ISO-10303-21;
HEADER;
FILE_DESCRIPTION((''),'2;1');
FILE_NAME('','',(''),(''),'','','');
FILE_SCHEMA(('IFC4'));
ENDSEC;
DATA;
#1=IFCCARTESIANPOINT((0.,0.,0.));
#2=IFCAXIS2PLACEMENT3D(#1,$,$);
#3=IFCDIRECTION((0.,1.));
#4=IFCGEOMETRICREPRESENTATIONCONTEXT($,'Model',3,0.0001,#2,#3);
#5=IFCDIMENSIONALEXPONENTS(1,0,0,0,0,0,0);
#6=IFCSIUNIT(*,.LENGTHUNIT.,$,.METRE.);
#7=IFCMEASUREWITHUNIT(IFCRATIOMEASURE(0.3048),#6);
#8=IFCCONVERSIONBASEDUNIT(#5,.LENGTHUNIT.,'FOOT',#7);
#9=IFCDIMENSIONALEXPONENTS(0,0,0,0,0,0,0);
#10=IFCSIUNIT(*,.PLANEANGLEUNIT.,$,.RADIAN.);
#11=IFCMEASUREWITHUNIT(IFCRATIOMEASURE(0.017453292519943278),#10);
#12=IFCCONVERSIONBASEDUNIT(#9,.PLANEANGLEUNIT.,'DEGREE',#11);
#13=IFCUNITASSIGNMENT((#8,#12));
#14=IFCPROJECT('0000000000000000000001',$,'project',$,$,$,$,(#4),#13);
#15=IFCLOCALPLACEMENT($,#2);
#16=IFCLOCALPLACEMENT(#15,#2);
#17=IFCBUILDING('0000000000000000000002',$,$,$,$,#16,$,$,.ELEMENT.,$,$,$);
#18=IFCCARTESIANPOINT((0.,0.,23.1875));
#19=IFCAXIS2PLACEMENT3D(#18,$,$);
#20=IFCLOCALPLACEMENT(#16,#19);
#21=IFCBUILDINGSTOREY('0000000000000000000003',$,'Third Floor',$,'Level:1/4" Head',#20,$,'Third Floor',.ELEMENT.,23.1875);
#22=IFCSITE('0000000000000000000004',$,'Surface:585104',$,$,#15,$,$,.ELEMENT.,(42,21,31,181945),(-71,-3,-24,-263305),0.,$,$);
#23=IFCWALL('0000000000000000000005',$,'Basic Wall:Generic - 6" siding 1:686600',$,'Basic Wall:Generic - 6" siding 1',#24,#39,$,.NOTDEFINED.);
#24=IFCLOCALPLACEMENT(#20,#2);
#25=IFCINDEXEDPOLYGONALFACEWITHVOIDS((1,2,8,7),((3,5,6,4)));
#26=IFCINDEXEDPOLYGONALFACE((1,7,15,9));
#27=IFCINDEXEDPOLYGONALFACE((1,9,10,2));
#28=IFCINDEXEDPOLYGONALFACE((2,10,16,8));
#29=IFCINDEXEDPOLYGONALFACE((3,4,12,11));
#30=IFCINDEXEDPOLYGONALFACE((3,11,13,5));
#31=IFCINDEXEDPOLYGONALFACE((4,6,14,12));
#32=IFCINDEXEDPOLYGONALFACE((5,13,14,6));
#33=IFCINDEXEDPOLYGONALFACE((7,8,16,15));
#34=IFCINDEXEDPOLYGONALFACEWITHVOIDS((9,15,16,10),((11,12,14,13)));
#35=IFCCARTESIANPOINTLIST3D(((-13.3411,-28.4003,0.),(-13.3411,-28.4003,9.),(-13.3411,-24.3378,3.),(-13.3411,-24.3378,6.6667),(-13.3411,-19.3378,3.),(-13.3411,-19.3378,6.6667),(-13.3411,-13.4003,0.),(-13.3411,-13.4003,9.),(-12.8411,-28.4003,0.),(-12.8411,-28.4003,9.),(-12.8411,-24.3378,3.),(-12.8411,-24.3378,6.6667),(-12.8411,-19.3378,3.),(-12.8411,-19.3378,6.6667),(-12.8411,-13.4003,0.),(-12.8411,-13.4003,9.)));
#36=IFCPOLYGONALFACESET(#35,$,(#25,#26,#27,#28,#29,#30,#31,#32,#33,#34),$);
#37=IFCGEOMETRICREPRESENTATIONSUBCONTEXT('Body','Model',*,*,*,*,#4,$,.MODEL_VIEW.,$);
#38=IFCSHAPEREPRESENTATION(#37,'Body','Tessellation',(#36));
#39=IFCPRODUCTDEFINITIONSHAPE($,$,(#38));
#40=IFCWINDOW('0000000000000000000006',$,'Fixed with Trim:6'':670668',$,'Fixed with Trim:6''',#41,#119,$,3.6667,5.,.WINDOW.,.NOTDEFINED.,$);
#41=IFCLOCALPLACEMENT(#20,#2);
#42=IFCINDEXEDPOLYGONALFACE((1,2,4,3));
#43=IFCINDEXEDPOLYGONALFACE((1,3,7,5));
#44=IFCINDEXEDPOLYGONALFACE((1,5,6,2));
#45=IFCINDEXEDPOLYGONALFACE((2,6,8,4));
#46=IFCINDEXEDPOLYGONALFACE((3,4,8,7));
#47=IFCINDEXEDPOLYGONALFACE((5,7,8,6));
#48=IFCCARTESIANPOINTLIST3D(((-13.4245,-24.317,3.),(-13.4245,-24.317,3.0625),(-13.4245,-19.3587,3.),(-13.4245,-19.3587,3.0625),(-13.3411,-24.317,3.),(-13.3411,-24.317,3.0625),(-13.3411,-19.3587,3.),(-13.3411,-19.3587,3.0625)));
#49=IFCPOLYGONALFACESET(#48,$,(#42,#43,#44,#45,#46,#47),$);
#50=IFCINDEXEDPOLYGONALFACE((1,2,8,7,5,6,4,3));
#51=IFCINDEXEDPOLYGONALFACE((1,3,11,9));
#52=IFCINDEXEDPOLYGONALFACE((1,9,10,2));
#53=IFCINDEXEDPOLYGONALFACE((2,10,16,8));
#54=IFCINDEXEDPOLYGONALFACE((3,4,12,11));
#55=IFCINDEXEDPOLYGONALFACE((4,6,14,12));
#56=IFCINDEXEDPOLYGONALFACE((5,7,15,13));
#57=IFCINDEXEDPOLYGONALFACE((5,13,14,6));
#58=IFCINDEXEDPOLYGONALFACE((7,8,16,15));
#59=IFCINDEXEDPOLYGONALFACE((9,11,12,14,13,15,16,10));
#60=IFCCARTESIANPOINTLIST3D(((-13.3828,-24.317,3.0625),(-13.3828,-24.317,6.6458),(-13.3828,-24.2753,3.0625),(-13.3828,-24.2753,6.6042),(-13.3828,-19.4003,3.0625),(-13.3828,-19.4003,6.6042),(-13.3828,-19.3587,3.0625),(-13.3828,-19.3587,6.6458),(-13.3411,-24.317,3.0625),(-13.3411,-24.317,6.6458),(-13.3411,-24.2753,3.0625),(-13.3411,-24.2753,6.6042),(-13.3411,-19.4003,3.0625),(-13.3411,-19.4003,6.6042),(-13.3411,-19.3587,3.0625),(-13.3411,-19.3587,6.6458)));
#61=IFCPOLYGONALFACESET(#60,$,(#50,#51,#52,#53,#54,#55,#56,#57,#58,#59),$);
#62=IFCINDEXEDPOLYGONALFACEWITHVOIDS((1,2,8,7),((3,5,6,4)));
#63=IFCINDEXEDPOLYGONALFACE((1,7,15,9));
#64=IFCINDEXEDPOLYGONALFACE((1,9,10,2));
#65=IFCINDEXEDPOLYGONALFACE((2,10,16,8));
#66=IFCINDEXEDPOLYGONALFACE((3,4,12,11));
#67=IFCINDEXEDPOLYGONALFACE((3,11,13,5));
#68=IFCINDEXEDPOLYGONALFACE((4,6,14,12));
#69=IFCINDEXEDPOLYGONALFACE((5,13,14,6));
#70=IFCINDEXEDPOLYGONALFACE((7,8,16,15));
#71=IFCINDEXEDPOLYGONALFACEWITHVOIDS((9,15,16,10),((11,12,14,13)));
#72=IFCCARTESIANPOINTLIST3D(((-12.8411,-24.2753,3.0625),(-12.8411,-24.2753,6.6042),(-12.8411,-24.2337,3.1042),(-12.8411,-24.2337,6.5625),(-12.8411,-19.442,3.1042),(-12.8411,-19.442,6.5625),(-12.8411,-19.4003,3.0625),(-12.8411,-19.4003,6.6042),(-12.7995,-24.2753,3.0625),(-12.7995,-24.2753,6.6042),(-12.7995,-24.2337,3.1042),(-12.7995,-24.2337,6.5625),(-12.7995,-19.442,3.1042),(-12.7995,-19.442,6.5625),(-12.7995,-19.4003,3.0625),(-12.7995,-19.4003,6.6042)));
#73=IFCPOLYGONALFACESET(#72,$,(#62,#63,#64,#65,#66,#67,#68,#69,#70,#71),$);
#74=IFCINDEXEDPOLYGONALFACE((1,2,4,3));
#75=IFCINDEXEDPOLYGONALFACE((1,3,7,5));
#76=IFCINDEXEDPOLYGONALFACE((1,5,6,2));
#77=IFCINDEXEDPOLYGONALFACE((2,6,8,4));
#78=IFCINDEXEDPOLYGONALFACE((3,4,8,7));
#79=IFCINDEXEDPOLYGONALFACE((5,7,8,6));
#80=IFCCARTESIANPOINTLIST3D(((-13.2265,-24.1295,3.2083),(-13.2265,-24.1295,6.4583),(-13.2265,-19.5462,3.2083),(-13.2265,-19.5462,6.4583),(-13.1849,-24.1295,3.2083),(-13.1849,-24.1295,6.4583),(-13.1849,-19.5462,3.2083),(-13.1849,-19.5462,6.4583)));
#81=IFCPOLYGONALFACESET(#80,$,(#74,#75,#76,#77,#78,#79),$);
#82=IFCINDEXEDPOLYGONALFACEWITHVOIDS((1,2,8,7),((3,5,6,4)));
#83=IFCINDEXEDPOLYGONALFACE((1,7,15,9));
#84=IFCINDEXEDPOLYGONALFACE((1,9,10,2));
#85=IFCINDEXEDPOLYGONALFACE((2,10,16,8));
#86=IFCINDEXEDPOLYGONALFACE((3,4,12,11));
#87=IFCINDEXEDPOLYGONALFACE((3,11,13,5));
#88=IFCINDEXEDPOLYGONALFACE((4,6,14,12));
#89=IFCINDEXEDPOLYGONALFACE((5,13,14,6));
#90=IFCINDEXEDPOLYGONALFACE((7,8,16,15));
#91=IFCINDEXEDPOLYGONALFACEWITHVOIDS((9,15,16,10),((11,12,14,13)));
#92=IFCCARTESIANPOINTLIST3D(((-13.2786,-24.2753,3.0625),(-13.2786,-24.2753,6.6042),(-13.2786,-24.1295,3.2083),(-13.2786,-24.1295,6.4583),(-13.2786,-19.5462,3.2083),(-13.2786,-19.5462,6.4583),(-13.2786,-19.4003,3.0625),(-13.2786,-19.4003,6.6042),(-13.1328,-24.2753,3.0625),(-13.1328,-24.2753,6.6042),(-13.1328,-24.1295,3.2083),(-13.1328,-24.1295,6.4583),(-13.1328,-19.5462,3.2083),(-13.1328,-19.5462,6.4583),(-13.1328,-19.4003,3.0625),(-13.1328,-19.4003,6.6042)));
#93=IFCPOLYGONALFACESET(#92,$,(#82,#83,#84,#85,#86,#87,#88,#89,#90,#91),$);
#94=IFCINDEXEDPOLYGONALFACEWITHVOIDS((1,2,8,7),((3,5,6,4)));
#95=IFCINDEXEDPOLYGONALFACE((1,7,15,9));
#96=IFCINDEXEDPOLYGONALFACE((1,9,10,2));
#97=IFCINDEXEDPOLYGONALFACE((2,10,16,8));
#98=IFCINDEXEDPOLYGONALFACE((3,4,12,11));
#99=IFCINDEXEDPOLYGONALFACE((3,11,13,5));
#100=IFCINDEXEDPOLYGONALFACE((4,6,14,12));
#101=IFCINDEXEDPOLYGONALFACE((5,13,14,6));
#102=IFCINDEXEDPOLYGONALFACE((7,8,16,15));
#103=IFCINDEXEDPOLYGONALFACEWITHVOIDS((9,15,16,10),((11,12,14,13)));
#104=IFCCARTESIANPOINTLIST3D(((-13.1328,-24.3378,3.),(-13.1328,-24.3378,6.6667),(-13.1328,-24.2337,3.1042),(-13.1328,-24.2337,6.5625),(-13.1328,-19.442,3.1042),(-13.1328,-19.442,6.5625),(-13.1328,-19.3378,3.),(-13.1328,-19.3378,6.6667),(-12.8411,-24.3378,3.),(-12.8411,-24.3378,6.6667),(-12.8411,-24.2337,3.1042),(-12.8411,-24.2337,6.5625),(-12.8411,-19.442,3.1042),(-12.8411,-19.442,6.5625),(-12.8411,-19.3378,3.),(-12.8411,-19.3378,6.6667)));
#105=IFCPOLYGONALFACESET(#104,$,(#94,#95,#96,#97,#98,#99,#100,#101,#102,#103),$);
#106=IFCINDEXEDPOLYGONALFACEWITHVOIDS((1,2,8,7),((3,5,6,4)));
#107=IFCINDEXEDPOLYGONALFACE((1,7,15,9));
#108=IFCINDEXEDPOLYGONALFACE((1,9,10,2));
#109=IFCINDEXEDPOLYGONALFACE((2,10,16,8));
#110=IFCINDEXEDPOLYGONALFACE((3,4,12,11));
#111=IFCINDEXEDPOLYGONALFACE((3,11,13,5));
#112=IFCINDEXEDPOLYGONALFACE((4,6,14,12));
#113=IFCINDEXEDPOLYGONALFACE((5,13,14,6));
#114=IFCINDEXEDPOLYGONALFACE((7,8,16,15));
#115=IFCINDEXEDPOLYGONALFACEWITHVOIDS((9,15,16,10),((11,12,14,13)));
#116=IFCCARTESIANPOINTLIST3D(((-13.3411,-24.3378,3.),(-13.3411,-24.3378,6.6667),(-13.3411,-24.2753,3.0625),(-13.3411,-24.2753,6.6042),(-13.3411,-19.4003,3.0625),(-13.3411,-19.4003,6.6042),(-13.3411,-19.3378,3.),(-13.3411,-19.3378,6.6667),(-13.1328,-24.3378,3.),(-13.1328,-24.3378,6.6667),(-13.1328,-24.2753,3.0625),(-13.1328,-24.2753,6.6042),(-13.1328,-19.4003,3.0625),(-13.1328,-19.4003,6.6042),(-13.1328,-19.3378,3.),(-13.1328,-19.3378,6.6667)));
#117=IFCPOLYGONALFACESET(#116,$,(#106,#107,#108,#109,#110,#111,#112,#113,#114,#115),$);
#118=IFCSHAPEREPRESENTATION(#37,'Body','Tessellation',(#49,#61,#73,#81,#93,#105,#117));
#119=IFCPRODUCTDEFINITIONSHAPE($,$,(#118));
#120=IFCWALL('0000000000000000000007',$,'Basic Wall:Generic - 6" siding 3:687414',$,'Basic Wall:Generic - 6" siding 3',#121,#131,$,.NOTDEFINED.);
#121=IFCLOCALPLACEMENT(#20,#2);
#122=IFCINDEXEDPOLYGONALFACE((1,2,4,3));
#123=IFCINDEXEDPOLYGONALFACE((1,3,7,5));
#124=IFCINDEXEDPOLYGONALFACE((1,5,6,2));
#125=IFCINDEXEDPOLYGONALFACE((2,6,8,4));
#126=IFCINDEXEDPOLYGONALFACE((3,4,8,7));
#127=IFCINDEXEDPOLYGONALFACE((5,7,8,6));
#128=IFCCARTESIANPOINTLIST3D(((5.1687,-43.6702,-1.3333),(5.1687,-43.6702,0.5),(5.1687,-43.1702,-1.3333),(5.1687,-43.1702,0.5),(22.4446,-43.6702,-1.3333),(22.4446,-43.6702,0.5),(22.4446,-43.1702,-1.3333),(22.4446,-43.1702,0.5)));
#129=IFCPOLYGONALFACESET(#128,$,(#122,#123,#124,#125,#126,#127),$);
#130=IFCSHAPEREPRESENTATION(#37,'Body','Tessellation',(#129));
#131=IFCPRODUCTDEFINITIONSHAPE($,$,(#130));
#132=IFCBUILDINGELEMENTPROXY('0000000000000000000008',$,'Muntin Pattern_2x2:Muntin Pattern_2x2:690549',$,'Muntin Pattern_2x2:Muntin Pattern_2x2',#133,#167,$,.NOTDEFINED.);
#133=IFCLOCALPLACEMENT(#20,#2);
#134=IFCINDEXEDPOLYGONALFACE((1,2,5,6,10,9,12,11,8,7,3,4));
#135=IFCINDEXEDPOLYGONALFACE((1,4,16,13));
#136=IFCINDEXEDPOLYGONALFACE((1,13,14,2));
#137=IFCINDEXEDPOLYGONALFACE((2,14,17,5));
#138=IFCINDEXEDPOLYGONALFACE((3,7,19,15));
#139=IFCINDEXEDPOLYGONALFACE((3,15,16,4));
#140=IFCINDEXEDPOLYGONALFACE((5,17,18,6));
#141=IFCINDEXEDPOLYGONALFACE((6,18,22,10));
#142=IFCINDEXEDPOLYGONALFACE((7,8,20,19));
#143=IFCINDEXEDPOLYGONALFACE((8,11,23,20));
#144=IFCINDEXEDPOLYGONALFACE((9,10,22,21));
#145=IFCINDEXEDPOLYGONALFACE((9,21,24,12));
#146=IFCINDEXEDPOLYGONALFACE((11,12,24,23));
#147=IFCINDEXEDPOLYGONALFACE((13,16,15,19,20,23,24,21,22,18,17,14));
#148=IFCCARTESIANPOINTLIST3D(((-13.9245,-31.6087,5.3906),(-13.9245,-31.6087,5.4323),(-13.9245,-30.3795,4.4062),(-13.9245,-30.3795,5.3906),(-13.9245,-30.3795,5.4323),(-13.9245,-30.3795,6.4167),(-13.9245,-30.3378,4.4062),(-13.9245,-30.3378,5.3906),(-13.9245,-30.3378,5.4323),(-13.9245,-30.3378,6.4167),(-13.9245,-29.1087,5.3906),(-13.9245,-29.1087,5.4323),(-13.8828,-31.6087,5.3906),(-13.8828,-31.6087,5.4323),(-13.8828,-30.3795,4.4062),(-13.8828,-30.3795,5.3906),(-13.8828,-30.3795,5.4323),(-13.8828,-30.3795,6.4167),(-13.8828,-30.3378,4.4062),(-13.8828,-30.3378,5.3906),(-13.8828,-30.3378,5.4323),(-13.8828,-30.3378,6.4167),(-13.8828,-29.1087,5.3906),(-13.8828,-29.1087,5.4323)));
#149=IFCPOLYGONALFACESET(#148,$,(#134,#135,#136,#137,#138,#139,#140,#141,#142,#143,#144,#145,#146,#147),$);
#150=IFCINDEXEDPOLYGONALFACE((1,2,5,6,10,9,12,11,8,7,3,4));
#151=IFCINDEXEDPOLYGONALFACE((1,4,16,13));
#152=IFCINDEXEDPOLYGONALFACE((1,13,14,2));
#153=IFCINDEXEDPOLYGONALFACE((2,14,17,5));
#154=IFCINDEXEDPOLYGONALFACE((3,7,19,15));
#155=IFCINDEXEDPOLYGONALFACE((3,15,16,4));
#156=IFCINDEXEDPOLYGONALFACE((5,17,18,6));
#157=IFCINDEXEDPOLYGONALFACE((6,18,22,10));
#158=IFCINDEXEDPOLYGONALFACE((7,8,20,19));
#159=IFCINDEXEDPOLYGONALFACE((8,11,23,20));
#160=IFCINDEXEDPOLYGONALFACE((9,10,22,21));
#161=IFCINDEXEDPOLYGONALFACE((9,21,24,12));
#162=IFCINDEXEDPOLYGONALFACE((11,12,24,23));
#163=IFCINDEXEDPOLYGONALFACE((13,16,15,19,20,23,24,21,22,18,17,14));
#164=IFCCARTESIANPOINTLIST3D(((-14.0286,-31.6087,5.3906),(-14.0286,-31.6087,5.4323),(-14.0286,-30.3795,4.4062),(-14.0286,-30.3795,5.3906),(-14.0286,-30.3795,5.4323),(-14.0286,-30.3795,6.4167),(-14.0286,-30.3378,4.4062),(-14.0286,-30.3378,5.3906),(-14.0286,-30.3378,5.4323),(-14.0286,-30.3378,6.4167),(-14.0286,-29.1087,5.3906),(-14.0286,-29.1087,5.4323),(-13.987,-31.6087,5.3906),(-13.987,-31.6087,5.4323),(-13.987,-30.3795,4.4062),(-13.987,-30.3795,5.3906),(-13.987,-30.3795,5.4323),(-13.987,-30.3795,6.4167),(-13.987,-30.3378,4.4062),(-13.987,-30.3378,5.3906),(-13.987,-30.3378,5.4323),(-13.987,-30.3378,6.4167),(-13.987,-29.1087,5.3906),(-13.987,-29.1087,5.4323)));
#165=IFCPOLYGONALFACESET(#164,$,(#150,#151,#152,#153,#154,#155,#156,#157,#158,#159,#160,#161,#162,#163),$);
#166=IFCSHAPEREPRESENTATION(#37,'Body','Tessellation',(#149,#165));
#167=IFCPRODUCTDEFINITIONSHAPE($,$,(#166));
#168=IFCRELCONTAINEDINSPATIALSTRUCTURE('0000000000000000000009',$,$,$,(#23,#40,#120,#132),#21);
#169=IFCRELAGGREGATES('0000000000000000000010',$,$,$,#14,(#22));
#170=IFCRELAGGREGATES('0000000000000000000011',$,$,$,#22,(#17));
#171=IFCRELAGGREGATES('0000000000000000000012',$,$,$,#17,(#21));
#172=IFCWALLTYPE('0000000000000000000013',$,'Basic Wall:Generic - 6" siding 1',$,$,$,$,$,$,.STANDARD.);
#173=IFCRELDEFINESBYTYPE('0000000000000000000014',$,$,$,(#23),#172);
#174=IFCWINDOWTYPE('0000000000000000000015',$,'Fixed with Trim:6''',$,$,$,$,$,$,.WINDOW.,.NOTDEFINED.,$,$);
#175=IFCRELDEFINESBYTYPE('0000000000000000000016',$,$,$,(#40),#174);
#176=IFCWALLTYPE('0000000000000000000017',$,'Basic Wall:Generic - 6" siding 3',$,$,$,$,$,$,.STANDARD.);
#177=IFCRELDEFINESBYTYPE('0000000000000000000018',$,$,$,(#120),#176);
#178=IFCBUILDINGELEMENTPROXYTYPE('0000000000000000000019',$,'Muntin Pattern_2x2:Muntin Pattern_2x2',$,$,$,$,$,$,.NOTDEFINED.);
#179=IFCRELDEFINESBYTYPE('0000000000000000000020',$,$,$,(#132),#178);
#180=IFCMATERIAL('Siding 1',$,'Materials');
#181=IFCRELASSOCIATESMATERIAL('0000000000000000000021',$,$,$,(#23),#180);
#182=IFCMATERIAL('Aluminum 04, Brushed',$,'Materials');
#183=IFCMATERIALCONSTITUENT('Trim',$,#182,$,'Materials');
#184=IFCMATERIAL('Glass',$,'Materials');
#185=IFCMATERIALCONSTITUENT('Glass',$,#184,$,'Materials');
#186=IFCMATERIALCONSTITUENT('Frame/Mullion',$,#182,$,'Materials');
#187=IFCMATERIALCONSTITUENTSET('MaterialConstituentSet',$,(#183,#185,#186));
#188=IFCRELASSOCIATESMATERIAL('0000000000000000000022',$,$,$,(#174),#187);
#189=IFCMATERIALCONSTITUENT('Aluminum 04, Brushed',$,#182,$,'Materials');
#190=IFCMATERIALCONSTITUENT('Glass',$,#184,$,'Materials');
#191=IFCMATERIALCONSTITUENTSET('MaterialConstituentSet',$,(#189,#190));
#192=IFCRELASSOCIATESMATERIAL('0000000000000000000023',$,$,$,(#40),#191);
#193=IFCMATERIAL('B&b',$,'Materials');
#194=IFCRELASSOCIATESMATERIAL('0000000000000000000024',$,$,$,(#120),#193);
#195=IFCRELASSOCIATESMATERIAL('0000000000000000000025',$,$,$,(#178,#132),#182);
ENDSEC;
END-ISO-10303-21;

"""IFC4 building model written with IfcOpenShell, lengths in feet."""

from ifc_helpers import new_model, entity, si_unit, converted_unit, direction, frame, origin, place, context, subcontext, project, spatial, indexed_curve, outline, extrude, source, transform, mapped, material, constituent, constituent_set, type_object, type_shapes, element, fill, save


model = new_model("IFC4")

# Units and contexts
model_context = context("Model", 3, precision=0.0001, world=origin(), true_north=direction((0.0, 1.0)))
body_context = subcontext(model_context, "Body", "Model", "MODEL_VIEW")
ifc_project = project(units=[converted_unit("LENGTHUNIT", "FOOT", entity("IfcRatioMeasure", 0.3048), si_unit("LENGTHUNIT", "METRE"), dimensions=[1, 0, 0, 0, 0, 0, 0]), converted_unit("PLANEANGLEUNIT", "DEGREE", entity("IfcRatioMeasure", 0.017453292519943278), si_unit("PLANEANGLEUNIT", "RADIAN"), dimensions=[0, 0, 0, 0, 0, 0, 0])], contexts=[model_context])

# Site, building, storey
site_placement = place(None, origin())
site = spatial("IfcSite", under=ifc_project, at=site_placement, Name="Surface:585104", CompositionType="ELEMENT", RefLatitude=(42, 21, 31, 181945), RefLongitude=(-71, -3, -24, -263305), RefElevation=0.0)
building_placement = place(site_placement, origin())
building = spatial("IfcBuilding", under=site, at=building_placement, CompositionType="ELEMENT")
storey_placement = place(building_placement, frame((0.0, 0.0, 23.1875)))
storey = spatial("IfcBuildingStorey", under=building, at=storey_placement, Name="Third Floor", ObjectType="Level:1/4\" Head", LongName="Third Floor", CompositionType="ELEMENT", Elevation=23.1875)

# Wall, openings, window
ifc_material_1 = material(Name="Siding 1", Category="Materials")
wall_type_1 = type_object("IfcWallType", Name="Basic Wall:Generic - 6\" siding 1", PredefinedType="STANDARD")
wall_1_placement = place(storey_placement, frame((-13.0911, -28.4003, 0.0), z_axis=(0.0, 0.0, 1.0), x_axis=(0.0, 1.0, 0.0)))
wall_1 = element("IfcWall", 1, at=wall_1_placement, inside=storey, type_object=wall_type_1, material=ifc_material_1, Name="Basic Wall:Generic - 6\" siding 1:686600", ObjectType="Basic Wall:Generic - 6\" siding 1", PredefinedType="NOTDEFINED", context=body_context, shape_type="SweptSolid", body=[
    extrude(outline(indexed_curve([(-0.25, -7.5), (0.25, -7.5), (0.25, 7.5), (-0.25, 7.5), (-0.25, -7.5)], self_intersect=False)), frame((7.5, 0.0, 0.0), z_axis=(0.0, 0.0, 1.0), x_axis=(0.0, 1.0, 0.0)), (0.0, 0.0, 1.0), 9.0),
])
opening_1_placement = place(storey_placement, frame((-13.0911, -28.4003, 0.0), z_axis=(0.0, 0.0, 1.0), x_axis=(0.0, 1.0, 0.0)))
element("IfcOpeningElement", 2, at=opening_1_placement, cuts=wall_1, PredefinedType="OPENING", context=body_context, shape_type="SweptSolid", body=[
    extrude(outline(indexed_curve([(-2.5, -1.8333), (2.5, -1.8333), (2.5, 1.8333), (-2.5, 1.8333), (-2.5, -1.8333)], self_intersect=False)), frame((6.5625, 0.25, 4.8333), z_axis=(0.0, -1.0, 0.0), x_axis=(-1.0, 0.0, 0.0)), (0.0, 0.0, 1.0), 0.5),
])
opening_2_placement = place(wall_1_placement, frame((4.0625, -0.25, 3.0)))
opening_2 = element("IfcOpeningElement", 3, at=opening_2_placement, cuts=wall_1, PredefinedType="OPENING", context=body_context, shape_type="SweptSolid", body=[
    extrude(outline(indexed_curve([(3.6667, 5.0), (0.0, 5.0), (0.0, 0.0), (3.6667, 0.0), (3.6667, 5.0)], self_intersect=False)), frame((0.0, 0.0, 0.0), z_axis=(0.0, 1.0, 0.0), x_axis=(0.0, 0.0, 1.0)), (0.0, 0.0, 1.0), 0.5),
])
ifc_material_2 = material(Name="Aluminum 04, Brushed", Category="Materials")
ifc_constituent_1 = constituent(ifc_material_2, Name="Aluminum 04, Brushed", Category="Materials")
ifc_material_3 = material(Name="Glass", Category="Materials")
ifc_constituent_2 = constituent(ifc_material_3, Name="Glass", Category="Materials")
ifc_constituent_set_1 = constituent_set(constituents=[ifc_constituent_1, ifc_constituent_2], Name="MaterialConstituentSet")
ifc_constituent_3 = constituent(ifc_material_2, Name="Trim", Category="Materials")
ifc_constituent_4 = constituent(ifc_material_3, Name="Glass", Category="Materials")
ifc_constituent_5 = constituent(ifc_material_2, Name="Frame/Mullion", Category="Materials")
ifc_constituent_set_2 = constituent_set(constituents=[ifc_constituent_3, ifc_constituent_4, ifc_constituent_5], Name="MaterialConstituentSet")
window_type = type_object("IfcWindowType", Name="Fixed with Trim:6'", PartitioningType="NOTDEFINED", PredefinedType="WINDOW", material=ifc_constituent_set_2)
shared_shape_1 = source(origin(), body_context, "Body", "SweptSolid", [
    extrude(outline(indexed_curve([(-0.0417, -2.4792), (0.0417, -2.4792), (0.0417, 2.4792), (-0.0417, 2.4792), (-0.0417, -2.4792)], self_intersect=False)), frame((2.5, 0.5417, 0.0), z_axis=(0.0, 0.0, 1.0), x_axis=(0.0, -1.0, 0.0)), (0.0, 0.0, 1.0), 0.0625),
    extrude(outline(indexed_curve([(-1.7604, 2.4375), (1.7812, 2.4375), (1.7812, 2.4792), (-1.8021, 2.4792), (-1.8021, -2.4792), (1.7812, -2.4792), (1.7812, -2.4375), (-1.7604, -2.4375), (-1.7604, 2.4375)], self_intersect=False)), frame((2.5, 0.5, 1.8437), z_axis=(0.0, 1.0, 0.0), x_axis=(0.0, 0.0, -1.0)), (0.0, 0.0, 1.0), 0.0417),
    extrude(outline(indexed_curve([(-1.7708, -2.4375), (1.7708, -2.4375), (1.7708, 2.4375), (-1.7708, 2.4375), (-1.7708, -2.4375)], self_intersect=False), holes=[indexed_curve([(-1.7292, -2.3958), (-1.7292, 2.3958), (1.7292, 2.3958), (1.7292, -2.3958), (-1.7292, -2.3958)], self_intersect=False)]), frame((2.5, -0.0417, 1.8333), z_axis=(0.0, 1.0, 0.0), x_axis=(0.0, 0.0, -1.0)), (0.0, 0.0, 1.0), 0.0417),
    extrude(outline(indexed_curve([(-0.0208, -2.2917), (0.0208, -2.2917), (0.0208, 2.2917), (-0.0208, 2.2917), (-0.0208, -2.2917)], self_intersect=False)), frame((2.5, 0.3646, 0.2083), z_axis=(0.0, 0.0, 1.0), x_axis=(0.0, 1.0, 0.0)), (0.0, 0.0, 1.0), 3.25),
    extrude(outline(indexed_curve([(-2.4375, -1.7708), (2.4375, -1.7708), (2.4375, 1.7708), (-2.4375, 1.7708), (-2.4375, -1.7708)], self_intersect=False), holes=[indexed_curve([(-2.2917, -1.625), (-2.2917, 1.625), (2.2917, 1.625), (2.2917, -1.625), (-2.2917, -1.625)], self_intersect=False)]), frame((2.5, 0.2917, 1.8333), z_axis=(0.0, 1.0, 0.0), x_axis=(1.0, 0.0, 0.0)), (0.0, 0.0, 1.0), 0.1458),
    extrude(outline(indexed_curve([(-2.5, -1.8333), (2.5, -1.8333), (2.5, 1.8333), (-2.5, 1.8333), (-2.5, -1.8333)], self_intersect=False), holes=[indexed_curve([(-2.3958, -1.7292), (-2.3958, 1.7292), (2.3958, 1.7292), (2.3958, -1.7292), (-2.3958, -1.7292)], self_intersect=False)]), frame((2.5, 0.0, 1.8333), z_axis=(0.0, 1.0, 0.0), x_axis=(1.0, 0.0, 0.0)), (0.0, 0.0, 1.0), 0.2917),
    extrude(outline(indexed_curve([(-1.8333, -2.5), (1.8333, -2.5), (1.8333, 2.5), (-1.8333, 2.5), (-1.8333, -2.5)], self_intersect=False), holes=[indexed_curve([(-1.7708, -2.4375), (-1.7708, 2.4375), (1.7708, 2.4375), (1.7708, -2.4375), (-1.7708, -2.4375)], self_intersect=False)]), frame((2.5, 0.2917, 1.8333), z_axis=(0.0, 1.0, 0.0), x_axis=(0.0, 0.0, -1.0)), (0.0, 0.0, 1.0), 0.2083),
])
type_shapes(window_type, [shared_shape_1])
window_placement = place(opening_2_placement, origin())
window = element("IfcWindow", 4, at=window_placement, inside=storey, type_object=window_type, material=ifc_constituent_set_1, Name="Fixed with Trim:6':670668", ObjectType="Fixed with Trim:6'", OverallHeight=3.6667, OverallWidth=5.0, PartitioningType="NOTDEFINED", PredefinedType="WINDOW", context=body_context, shape_type="MappedRepresentation", body=[
    mapped(shared_shape_1, transform((0.0, 0.0, 0.0), scale=1.0)),
])
fill(opening_2, window)

# Wall
ifc_material_4 = material(Name="B&b", Category="Materials")
wall_type_2 = type_object("IfcWallType", Name="Basic Wall:Generic - 6\" siding 3", PredefinedType="STANDARD")
wall_2_placement = place(storey_placement, frame((5.1687, -43.4202, -1.3333)))
element("IfcWall", 5, at=wall_2_placement, inside=storey, type_object=wall_type_2, material=ifc_material_4, Name="Basic Wall:Generic - 6\" siding 3:687414", ObjectType="Basic Wall:Generic - 6\" siding 3", PredefinedType="NOTDEFINED", context=body_context, shape_type="SweptSolid", body=[
    extrude(outline(indexed_curve([(17.2759, -0.25), (17.2759, 0.25), (0.0, 0.25), (0.0, -0.25), (17.2759, -0.25)], self_intersect=False)), origin(), (0.0, 0.0, 1.0), 1.8333),
])

# Building element proxy
building_element_proxy_type_1 = type_object("IfcBuildingElementProxyType", Name="Muntin Pattern_2x2:Muntin Pattern_2x2", PredefinedType="NOTDEFINED", material=ifc_material_2)
shared_shape_2 = source(origin(), body_context, "Body", "SweptSolid", [
    extrude(outline(indexed_curve([(0.0208, -0.0208), (1.0052, -0.0208), (1.0052, 0.0208), (0.0208, 0.0208), (0.0208, 1.25), (-0.0208, 1.25), (-0.0208, 0.0208), (-1.0052, 0.0208), (-1.0052, -0.0208), (-0.0208, -0.0208), (-0.0208, -1.25), (0.0208, -1.25), (0.0208, -0.0208)], self_intersect=False)), frame((0.0, -0.0729, 1.0052), z_axis=(0.0, 1.0, 0.0), x_axis=(0.0, 0.0, 1.0)), (0.0, 0.0, 1.0), 0.0417),
    extrude(outline(indexed_curve([(0.0208, -0.0208), (1.0052, -0.0208), (1.0052, 0.0208), (0.0208, 0.0208), (0.0208, 1.25), (-0.0208, 1.25), (-0.0208, 0.0208), (-1.0052, 0.0208), (-1.0052, -0.0208), (-0.0208, -0.0208), (-0.0208, -1.25), (0.0208, -1.25), (0.0208, -0.0208)], self_intersect=False)), frame((0.0, 0.0313, 1.0052), z_axis=(0.0, 1.0, 0.0), x_axis=(0.0, 0.0, 1.0)), (0.0, 0.0, 1.0), 0.0417),
])
type_shapes(building_element_proxy_type_1, [shared_shape_2])
for number, where, z_axis, x_axis, name in (
    (6, (-13.9557, -30.3587, 4.4062), (0.0, 0.0, 1.0), (0.0, 1.0, 0.0), "Muntin Pattern_2x2:Muntin Pattern_2x2:690549"),
):
    element("IfcBuildingElementProxy", number, at=place(storey_placement, frame(where, z_axis=z_axis, x_axis=x_axis)), inside=storey, type_object=building_element_proxy_type_1, material=ifc_material_2, Name=name, ObjectType="Muntin Pattern_2x2:Muntin Pattern_2x2", PredefinedType="NOTDEFINED", context=body_context, shape_type="MappedRepresentation", body=[
        mapped(shared_shape_2, transform((0.0, 0.0, 0.0), scale=1.0)),
    ])

save(model, "model.ifc")
